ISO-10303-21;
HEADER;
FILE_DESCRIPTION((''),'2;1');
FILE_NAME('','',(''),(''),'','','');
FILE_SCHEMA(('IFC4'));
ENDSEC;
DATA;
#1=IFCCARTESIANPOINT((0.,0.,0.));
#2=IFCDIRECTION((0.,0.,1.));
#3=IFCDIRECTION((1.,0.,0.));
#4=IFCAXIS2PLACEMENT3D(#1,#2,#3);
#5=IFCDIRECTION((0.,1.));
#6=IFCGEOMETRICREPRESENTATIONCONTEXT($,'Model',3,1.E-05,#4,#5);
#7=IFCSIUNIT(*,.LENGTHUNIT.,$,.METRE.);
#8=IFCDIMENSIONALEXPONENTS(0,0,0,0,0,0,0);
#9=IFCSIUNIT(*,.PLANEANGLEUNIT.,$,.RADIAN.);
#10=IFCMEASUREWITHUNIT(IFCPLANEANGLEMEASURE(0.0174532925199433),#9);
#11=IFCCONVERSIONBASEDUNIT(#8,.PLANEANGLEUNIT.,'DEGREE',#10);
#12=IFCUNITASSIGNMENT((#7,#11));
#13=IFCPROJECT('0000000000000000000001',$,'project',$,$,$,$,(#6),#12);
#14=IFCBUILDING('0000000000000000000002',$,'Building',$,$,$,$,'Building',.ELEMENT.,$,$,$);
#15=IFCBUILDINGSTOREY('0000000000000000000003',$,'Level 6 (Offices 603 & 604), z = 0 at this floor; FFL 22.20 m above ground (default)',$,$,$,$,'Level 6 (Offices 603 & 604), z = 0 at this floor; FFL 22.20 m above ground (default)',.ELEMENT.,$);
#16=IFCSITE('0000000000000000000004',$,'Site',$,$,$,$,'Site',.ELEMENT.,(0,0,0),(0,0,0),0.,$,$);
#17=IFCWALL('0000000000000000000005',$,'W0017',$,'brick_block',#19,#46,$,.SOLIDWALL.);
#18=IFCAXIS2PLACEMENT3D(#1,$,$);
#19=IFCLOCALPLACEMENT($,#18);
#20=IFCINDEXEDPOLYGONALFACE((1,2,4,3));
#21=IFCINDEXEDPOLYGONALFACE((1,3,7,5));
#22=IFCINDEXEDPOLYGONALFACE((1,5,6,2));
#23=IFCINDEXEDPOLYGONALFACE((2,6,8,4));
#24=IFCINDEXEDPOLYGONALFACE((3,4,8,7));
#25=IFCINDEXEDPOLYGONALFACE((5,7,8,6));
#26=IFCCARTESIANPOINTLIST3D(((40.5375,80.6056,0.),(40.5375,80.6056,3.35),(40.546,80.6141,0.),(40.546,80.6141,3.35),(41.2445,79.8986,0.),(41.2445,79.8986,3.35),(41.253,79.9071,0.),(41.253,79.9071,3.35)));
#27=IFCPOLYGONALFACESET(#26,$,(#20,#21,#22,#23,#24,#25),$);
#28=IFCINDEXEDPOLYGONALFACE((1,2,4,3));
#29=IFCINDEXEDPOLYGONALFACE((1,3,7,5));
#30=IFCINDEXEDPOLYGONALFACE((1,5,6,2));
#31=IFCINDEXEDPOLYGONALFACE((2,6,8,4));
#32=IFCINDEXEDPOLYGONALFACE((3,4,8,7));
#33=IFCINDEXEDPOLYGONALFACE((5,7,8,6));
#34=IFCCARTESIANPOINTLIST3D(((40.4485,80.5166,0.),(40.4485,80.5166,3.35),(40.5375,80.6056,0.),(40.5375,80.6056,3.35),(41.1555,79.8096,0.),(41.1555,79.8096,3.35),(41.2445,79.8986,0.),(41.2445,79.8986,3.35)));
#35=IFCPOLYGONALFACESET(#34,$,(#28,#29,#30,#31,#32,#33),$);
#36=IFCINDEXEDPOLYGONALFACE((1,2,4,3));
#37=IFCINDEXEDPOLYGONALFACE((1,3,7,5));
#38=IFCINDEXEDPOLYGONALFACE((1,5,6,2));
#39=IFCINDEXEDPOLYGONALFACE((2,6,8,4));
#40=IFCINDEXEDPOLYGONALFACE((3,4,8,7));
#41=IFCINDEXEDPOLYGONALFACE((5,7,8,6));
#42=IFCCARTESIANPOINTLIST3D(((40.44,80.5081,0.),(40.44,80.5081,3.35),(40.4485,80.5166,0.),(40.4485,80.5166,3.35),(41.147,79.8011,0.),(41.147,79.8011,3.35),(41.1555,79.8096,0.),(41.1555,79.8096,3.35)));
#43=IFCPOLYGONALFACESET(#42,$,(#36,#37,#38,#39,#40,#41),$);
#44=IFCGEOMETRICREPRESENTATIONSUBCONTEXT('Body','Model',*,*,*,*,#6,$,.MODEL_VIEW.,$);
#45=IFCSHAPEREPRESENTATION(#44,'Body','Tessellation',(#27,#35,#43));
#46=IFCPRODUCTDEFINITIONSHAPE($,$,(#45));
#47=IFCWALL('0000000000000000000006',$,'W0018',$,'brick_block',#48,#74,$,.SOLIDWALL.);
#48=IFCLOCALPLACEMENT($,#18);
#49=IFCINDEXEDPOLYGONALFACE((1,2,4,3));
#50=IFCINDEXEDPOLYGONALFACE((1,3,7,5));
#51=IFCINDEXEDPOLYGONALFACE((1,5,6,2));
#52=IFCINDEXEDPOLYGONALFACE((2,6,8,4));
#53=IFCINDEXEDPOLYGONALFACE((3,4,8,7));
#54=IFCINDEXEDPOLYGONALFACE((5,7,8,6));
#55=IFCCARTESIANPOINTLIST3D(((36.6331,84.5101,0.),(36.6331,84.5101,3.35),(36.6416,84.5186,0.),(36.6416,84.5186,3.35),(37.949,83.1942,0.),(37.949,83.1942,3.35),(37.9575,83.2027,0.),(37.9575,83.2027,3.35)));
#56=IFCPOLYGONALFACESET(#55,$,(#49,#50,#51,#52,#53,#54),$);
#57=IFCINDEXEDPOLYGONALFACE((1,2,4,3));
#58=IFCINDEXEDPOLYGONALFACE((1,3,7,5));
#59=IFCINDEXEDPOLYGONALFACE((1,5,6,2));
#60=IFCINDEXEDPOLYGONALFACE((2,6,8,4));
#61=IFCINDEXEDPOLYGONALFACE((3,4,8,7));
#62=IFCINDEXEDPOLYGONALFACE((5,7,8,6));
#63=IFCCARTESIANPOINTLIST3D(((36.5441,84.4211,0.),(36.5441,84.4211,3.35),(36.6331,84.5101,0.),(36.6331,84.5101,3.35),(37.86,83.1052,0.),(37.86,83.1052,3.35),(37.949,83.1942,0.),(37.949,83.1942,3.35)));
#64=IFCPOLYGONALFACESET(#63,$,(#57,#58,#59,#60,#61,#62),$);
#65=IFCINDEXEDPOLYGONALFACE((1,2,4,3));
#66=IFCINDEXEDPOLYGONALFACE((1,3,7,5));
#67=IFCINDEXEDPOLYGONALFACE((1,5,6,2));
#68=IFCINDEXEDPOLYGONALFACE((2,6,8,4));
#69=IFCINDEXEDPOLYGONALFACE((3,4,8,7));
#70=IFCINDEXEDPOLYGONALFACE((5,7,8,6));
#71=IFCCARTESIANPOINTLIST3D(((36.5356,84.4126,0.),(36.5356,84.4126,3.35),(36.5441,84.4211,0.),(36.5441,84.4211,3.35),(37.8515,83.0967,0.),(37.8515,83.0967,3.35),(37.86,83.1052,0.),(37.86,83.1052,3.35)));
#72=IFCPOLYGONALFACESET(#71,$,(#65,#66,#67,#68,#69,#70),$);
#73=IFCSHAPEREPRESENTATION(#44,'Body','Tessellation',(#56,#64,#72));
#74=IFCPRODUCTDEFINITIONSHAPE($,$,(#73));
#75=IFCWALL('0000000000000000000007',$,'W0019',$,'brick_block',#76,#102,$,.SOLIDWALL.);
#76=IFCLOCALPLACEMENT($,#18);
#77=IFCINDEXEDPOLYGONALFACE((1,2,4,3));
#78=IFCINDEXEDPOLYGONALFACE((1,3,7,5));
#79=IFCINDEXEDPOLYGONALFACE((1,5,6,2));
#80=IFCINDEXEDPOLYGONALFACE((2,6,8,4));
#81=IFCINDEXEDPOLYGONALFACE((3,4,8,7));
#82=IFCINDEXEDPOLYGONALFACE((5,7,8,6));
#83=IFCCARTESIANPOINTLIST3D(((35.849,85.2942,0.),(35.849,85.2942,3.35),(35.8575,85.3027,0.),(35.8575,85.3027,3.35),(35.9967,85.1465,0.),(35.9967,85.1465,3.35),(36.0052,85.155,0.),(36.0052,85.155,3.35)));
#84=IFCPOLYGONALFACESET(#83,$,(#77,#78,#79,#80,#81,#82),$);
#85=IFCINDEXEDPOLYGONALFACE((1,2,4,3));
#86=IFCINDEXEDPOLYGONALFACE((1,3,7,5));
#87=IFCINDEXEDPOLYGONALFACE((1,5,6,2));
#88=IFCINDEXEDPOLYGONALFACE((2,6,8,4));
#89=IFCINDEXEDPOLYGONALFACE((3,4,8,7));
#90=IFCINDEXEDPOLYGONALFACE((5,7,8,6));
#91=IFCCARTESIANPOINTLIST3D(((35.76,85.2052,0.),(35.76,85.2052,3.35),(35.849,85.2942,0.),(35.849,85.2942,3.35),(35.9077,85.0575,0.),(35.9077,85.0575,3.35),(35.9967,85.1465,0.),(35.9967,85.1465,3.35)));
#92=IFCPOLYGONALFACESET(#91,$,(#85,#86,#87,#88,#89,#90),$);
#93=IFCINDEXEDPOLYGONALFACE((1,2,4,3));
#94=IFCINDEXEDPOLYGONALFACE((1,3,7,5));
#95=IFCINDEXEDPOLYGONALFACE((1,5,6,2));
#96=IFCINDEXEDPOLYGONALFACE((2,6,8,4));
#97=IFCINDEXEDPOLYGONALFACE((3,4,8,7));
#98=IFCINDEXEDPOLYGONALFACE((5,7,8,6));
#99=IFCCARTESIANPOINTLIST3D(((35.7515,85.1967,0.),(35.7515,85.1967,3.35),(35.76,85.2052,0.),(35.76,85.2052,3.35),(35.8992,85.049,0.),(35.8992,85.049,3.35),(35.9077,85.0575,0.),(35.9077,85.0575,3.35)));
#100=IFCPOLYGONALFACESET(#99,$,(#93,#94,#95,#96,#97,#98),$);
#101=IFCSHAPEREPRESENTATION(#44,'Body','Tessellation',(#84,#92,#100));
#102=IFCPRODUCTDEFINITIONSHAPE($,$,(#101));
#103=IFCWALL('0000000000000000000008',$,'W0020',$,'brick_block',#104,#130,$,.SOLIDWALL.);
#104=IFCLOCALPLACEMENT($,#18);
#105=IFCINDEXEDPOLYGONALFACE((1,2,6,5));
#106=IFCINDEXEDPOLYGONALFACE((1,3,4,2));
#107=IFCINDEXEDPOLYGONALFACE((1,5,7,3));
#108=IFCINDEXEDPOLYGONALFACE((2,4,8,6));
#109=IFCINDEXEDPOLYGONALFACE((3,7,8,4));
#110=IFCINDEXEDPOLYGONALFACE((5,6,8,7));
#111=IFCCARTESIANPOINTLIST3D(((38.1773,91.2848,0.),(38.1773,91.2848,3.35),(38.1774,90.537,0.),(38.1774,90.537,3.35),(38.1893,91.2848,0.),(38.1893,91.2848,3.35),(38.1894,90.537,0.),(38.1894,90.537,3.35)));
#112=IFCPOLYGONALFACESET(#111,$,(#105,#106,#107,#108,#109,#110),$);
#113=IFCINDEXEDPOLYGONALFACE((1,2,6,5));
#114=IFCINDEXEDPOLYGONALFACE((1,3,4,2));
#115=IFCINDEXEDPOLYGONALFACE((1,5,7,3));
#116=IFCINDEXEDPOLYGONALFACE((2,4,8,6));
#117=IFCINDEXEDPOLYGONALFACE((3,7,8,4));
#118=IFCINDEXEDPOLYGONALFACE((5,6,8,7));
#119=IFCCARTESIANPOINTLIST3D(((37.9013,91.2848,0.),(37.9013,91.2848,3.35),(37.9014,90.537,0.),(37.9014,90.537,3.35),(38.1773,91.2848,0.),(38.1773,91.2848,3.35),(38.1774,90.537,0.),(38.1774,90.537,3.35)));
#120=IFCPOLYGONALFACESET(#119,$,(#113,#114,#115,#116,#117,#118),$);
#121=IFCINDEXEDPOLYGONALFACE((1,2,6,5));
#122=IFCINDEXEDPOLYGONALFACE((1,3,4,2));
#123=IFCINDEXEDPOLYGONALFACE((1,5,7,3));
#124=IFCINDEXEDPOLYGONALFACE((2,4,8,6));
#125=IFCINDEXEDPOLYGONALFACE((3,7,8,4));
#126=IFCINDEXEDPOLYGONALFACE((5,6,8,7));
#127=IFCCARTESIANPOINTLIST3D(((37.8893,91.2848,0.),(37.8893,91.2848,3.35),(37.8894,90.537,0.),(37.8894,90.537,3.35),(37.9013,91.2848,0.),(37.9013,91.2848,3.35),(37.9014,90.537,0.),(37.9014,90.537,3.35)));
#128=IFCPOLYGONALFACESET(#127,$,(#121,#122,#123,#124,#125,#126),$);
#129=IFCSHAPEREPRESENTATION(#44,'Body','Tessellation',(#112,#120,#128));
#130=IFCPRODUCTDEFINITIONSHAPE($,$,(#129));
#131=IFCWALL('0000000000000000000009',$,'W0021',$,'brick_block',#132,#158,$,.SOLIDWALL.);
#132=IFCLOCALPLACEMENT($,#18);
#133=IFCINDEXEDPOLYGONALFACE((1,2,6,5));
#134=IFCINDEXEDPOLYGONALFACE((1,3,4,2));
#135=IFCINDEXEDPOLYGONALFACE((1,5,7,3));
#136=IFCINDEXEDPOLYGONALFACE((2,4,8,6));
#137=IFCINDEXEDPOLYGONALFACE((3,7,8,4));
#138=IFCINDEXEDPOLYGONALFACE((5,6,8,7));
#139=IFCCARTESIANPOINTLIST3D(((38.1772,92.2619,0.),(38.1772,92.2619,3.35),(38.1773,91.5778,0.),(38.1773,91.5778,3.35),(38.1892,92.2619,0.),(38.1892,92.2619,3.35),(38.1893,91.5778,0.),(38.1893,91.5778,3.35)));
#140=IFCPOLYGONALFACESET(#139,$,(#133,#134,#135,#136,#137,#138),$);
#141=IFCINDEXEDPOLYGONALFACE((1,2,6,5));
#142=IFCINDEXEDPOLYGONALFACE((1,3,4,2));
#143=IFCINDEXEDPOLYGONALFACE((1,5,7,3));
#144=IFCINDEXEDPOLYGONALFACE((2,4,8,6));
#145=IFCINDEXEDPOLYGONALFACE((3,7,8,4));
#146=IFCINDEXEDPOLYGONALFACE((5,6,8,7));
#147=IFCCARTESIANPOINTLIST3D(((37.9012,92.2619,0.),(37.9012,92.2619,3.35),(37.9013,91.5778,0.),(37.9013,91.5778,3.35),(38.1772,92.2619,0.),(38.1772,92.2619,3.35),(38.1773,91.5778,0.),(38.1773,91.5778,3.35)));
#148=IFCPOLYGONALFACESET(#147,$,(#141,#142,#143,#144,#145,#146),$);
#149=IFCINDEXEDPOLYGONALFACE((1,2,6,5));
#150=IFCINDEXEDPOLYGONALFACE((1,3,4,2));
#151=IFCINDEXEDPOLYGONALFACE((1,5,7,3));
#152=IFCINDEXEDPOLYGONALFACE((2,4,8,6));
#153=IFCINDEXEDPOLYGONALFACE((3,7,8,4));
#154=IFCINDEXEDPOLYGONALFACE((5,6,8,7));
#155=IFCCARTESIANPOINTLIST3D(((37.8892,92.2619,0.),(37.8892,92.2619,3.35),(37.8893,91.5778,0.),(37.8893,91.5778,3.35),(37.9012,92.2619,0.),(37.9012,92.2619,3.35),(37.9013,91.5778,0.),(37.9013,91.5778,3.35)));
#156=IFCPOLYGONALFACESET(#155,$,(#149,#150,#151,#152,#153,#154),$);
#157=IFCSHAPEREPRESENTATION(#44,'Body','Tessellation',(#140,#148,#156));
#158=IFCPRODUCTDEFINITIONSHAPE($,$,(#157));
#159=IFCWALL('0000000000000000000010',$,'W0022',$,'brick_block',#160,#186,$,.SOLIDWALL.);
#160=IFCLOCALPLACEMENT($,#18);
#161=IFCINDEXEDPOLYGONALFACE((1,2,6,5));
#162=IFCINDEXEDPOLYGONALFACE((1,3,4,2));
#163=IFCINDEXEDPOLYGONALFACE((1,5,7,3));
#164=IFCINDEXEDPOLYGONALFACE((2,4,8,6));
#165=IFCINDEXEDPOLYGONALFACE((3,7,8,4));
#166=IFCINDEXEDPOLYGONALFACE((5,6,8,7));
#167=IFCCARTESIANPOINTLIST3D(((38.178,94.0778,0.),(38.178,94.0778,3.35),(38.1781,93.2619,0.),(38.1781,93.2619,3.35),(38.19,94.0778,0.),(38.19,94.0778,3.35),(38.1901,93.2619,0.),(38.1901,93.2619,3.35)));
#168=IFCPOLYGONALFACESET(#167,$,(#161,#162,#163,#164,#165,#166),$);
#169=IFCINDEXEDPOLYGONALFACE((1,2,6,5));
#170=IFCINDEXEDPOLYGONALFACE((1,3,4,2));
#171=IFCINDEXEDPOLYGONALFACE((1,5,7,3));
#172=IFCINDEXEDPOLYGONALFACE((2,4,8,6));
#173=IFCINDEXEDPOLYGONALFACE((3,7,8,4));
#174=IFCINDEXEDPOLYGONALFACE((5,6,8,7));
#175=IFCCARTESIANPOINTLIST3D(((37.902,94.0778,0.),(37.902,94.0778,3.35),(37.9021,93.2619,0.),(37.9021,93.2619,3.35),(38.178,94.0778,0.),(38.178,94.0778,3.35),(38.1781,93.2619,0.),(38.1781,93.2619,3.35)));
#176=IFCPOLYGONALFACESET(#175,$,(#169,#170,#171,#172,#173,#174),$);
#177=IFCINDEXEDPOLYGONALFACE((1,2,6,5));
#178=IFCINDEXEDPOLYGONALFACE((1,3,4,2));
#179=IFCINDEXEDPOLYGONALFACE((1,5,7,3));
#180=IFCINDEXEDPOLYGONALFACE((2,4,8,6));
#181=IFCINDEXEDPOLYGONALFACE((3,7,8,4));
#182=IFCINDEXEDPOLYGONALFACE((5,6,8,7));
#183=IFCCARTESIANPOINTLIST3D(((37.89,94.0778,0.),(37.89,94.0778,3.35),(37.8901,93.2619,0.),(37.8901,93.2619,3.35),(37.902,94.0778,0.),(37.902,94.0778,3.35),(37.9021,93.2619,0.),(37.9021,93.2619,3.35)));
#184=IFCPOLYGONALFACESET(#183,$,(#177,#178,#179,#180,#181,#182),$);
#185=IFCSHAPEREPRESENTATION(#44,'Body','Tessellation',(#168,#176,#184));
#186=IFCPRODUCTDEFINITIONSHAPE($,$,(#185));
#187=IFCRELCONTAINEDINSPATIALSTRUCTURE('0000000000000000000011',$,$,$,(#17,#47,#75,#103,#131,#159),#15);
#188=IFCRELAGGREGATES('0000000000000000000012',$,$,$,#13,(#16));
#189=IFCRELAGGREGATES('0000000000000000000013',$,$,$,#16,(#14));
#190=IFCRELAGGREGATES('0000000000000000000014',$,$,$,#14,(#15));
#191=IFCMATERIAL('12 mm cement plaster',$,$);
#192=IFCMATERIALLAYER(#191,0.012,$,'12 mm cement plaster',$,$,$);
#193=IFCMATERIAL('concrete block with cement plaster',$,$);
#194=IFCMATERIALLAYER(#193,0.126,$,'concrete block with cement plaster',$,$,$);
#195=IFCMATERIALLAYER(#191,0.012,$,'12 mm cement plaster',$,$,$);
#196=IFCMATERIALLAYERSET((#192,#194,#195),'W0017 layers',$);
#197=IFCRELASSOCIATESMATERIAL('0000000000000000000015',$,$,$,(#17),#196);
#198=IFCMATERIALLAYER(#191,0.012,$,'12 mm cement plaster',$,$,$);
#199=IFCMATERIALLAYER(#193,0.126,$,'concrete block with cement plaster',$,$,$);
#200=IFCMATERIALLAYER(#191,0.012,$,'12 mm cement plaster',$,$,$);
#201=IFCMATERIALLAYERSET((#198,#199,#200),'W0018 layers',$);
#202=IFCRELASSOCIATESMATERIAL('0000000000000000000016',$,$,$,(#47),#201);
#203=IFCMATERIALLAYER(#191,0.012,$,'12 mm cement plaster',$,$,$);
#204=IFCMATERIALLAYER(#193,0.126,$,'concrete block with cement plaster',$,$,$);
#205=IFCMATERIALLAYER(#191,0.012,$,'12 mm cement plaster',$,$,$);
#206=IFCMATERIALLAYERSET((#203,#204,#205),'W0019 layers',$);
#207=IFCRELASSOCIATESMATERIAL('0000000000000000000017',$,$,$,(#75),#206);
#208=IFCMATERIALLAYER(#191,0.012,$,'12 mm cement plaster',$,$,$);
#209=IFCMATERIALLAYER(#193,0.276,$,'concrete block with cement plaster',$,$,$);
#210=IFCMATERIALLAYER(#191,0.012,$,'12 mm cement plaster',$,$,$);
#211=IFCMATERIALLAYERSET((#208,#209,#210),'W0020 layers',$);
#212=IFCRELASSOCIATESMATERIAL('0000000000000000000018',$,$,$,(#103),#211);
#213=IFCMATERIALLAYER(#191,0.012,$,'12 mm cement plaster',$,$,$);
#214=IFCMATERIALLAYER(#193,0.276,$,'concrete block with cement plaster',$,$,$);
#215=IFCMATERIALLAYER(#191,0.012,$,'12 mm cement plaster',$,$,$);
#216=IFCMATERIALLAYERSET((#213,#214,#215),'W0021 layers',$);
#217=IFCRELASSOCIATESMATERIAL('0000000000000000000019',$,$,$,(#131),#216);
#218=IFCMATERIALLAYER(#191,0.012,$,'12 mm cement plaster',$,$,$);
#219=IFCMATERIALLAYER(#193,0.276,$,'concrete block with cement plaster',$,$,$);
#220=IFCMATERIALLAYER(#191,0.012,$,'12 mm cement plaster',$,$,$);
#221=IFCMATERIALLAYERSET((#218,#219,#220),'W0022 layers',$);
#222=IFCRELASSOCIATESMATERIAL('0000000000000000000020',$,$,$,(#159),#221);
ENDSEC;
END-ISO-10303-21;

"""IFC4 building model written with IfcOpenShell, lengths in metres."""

from ifc_helpers import new_model, entity, si_unit, converted_unit, direction, frame, frame_2d, origin_with_axes, place, context, subcontext, project, spatial, rectangle, extrude, material, layer, layer_set, layer_usage, element, save


model = new_model("IFC4")

# Units and contexts
model_context = context("Model", 3, precision=1e-05, world=origin_with_axes(), true_north=direction((0.0, 1.0)))
body_context = subcontext(model_context, "Body", "Model", "MODEL_VIEW")
ifc_project = project(units=[si_unit("LENGTHUNIT", "METRE"), converted_unit("PLANEANGLEUNIT", "DEGREE", entity("IfcPlaneAngleMeasure", 0.0174532925199433), si_unit("PLANEANGLEUNIT", "RADIAN"), dimensions=[0, 0, 0, 0, 0, 0, 0])], contexts=[model_context])

# Site, building, storey
site = spatial("IfcSite", under=ifc_project, Name="Site", LongName="Site", CompositionType="ELEMENT", RefLatitude=(0, 0, 0), RefLongitude=(0, 0, 0), RefElevation=0.0)
building = spatial("IfcBuilding", under=site, Name="Building", LongName="Building", CompositionType="ELEMENT")
storey = spatial("IfcBuildingStorey", under=building, Name="Level 6 (Offices 603 & 604), z = 0 at this floor; FFL 22.20 m above ground (default)", LongName="Level 6 (Offices 603 & 604), z = 0 at this floor; FFL 22.20 m above ground (default)", CompositionType="ELEMENT")

# Shared definitions
ifc_material_1 = material(Name="12 mm cement plaster")
ifc_material_2 = material(Name="concrete block with cement plaster")
placement = place(None, origin_with_axes())

# Walls
ifc_layer_1 = layer(ifc_material_1, 0.012, Name="12 mm cement plaster")
ifc_layer_2 = layer(ifc_material_2, 0.126, Name="concrete block with cement plaster")
ifc_layer_3 = layer(ifc_material_1, 0.012, Name="12 mm cement plaster")
ifc_layer_set_1 = layer_set([ifc_layer_1, ifc_layer_2, ifc_layer_3], Name="W0017 layers")
ifc_layer_usage_1 = layer_usage(ifc_layer_set_1, "AXIS2", "POSITIVE", -0.075)
element("IfcWall", 1, at=placement, inside=storey, material=ifc_layer_usage_1, Name="W0017", ObjectType="brick_block", PredefinedType="SOLIDWALL", context=body_context, shape_type="SweptSolid", body=[
    extrude(rectangle(XDim=0.9998, YDim=0.012, at=frame_2d((0.0, 0.0), x_axis=(0.707107, -0.707107))), frame((40.8953, 80.2564, 0.0), z_axis=(0.0, 0.0, 1.0), x_axis=(1.0, 0.0, 0.0)), (0.0, 0.0, 1.0), 3.35),
    extrude(rectangle(XDim=0.9998, YDim=0.126, at=frame_2d((-0.0488, -0.0488), x_axis=(0.707107, -0.707107))), frame((40.8953, 80.2564, 0.0), z_axis=(0.0, 0.0, 1.0), x_axis=(1.0, 0.0, 0.0)), (0.0, 0.0, 1.0), 3.35),
    extrude(rectangle(XDim=0.9998, YDim=0.012, at=frame_2d((-0.0976, -0.0976), x_axis=(0.707107, -0.707107))), frame((40.8953, 80.2564, 0.0), z_axis=(0.0, 0.0, 1.0), x_axis=(1.0, 0.0, 0.0)), (0.0, 0.0, 1.0), 3.35),
])
ifc_layer_4 = layer(ifc_material_1, 0.012, Name="12 mm cement plaster")
ifc_layer_5 = layer(ifc_material_2, 0.126, Name="concrete block with cement plaster")
ifc_layer_6 = layer(ifc_material_1, 0.012, Name="12 mm cement plaster")
ifc_layer_set_2 = layer_set([ifc_layer_4, ifc_layer_5, ifc_layer_6], Name="W0018 layers")
ifc_layer_usage_2 = layer_usage(ifc_layer_set_2, "AXIS2", "POSITIVE", -0.075)
element("IfcWall", 2, at=placement, inside=storey, material=ifc_layer_usage_2, Name="W0018", ObjectType="brick_block", PredefinedType="SOLIDWALL", context=body_context, shape_type="SweptSolid", body=[
    extrude(rectangle(XDim=1.861, YDim=0.012, at=frame_2d((0.0, 0.0), x_axis=(0.707107, -0.707107))), frame((37.2953, 83.8564, 0.0), z_axis=(0.0, 0.0, 1.0), x_axis=(1.0, 0.0, 0.0)), (0.0, 0.0, 1.0), 3.35),
    extrude(rectangle(XDim=1.861, YDim=0.126, at=frame_2d((-0.0488, -0.0488), x_axis=(0.707107, -0.707107))), frame((37.2953, 83.8564, 0.0), z_axis=(0.0, 0.0, 1.0), x_axis=(1.0, 0.0, 0.0)), (0.0, 0.0, 1.0), 3.35),
    extrude(rectangle(XDim=1.861, YDim=0.012, at=frame_2d((-0.0976, -0.0976), x_axis=(0.707107, -0.707107))), frame((37.2953, 83.8564, 0.0), z_axis=(0.0, 0.0, 1.0), x_axis=(1.0, 0.0, 0.0)), (0.0, 0.0, 1.0), 3.35),
])
ifc_layer_7 = layer(ifc_material_1, 0.012, Name="12 mm cement plaster")
ifc_layer_8 = layer(ifc_material_2, 0.126, Name="concrete block with cement plaster")
ifc_layer_9 = layer(ifc_material_1, 0.012, Name="12 mm cement plaster")
ifc_layer_set_3 = layer_set([ifc_layer_7, ifc_layer_8, ifc_layer_9], Name="W0019 layers")
ifc_layer_usage_3 = layer_usage(ifc_layer_set_3, "AXIS2", "POSITIVE", -0.075)
element("IfcWall", 3, at=placement, inside=storey, material=ifc_layer_usage_3, Name="W0019", ObjectType="brick_block", PredefinedType="SOLIDWALL", context=body_context, shape_type="SweptSolid", body=[
    extrude(rectangle(XDim=0.2089, YDim=0.012, at=frame_2d((0.0, 0.0), x_axis=(0.707107, -0.707107))), frame((35.9271, 85.2246, 0.0), z_axis=(0.0, 0.0, 1.0), x_axis=(1.0, 0.0, 0.0)), (0.0, 0.0, 1.0), 3.35),
    extrude(rectangle(XDim=0.2089, YDim=0.126, at=frame_2d((-0.0488, -0.0488), x_axis=(0.707107, -0.707107))), frame((35.9271, 85.2246, 0.0), z_axis=(0.0, 0.0, 1.0), x_axis=(1.0, 0.0, 0.0)), (0.0, 0.0, 1.0), 3.35),
    extrude(rectangle(XDim=0.2089, YDim=0.012, at=frame_2d((-0.0976, -0.0976), x_axis=(0.707107, -0.707107))), frame((35.9271, 85.2246, 0.0), z_axis=(0.0, 0.0, 1.0), x_axis=(1.0, 0.0, 0.0)), (0.0, 0.0, 1.0), 3.35),
])
ifc_layer_10 = layer(ifc_material_1, 0.012, Name="12 mm cement plaster")
ifc_layer_11 = layer(ifc_material_2, 0.276, Name="concrete block with cement plaster")
ifc_layer_12 = layer(ifc_material_1, 0.012, Name="12 mm cement plaster")
ifc_layer_set_4 = layer_set([ifc_layer_10, ifc_layer_11, ifc_layer_12], Name="W0020 layers")
ifc_layer_usage_4 = layer_usage(ifc_layer_set_4, "AXIS2", "POSITIVE", -0.15)
element("IfcWall", 4, at=placement, inside=storey, material=ifc_layer_usage_4, Name="W0020", ObjectType="brick_block", PredefinedType="SOLIDWALL", context=body_context, shape_type="SweptSolid", body=[
    extrude(rectangle(XDim=0.7478, YDim=0.012, at=frame_2d((0.0, 0.0), x_axis=(-0.000134, 1.0))), frame((38.1833, 90.9109, 0.0), z_axis=(0.0, 0.0, 1.0), x_axis=(1.0, 0.0, 0.0)), (0.0, 0.0, 1.0), 3.35),
    extrude(rectangle(XDim=0.7478, YDim=0.276, at=frame_2d((-0.144, 0.0), x_axis=(-0.000134, 1.0))), frame((38.1833, 90.9109, 0.0), z_axis=(0.0, 0.0, 1.0), x_axis=(1.0, 0.0, 0.0)), (0.0, 0.0, 1.0), 3.35),
    extrude(rectangle(XDim=0.7478, YDim=0.012, at=frame_2d((-0.288, 0.0), x_axis=(-0.000134, 1.0))), frame((38.1833, 90.9109, 0.0), z_axis=(0.0, 0.0, 1.0), x_axis=(1.0, 0.0, 0.0)), (0.0, 0.0, 1.0), 3.35),
])
ifc_layer_13 = layer(ifc_material_1, 0.012, Name="12 mm cement plaster")
ifc_layer_14 = layer(ifc_material_2, 0.276, Name="concrete block with cement plaster")
ifc_layer_15 = layer(ifc_material_1, 0.012, Name="12 mm cement plaster")
ifc_layer_set_5 = layer_set([ifc_layer_13, ifc_layer_14, ifc_layer_15], Name="W0021 layers")
ifc_layer_usage_5 = layer_usage(ifc_layer_set_5, "AXIS2", "POSITIVE", -0.15)
element("IfcWall", 5, at=placement, inside=storey, material=ifc_layer_usage_5, Name="W0021", ObjectType="brick_block", PredefinedType="SOLIDWALL", context=body_context, shape_type="SweptSolid", body=[
    extrude(rectangle(XDim=0.6841, YDim=0.012, at=frame_2d((0.0, 0.0), x_axis=(-0.000146, 1.0))), frame((38.1832, 91.9199, 0.0), z_axis=(0.0, 0.0, 1.0), x_axis=(1.0, 0.0, 0.0)), (0.0, 0.0, 1.0), 3.35),
    extrude(rectangle(XDim=0.6841, YDim=0.276, at=frame_2d((-0.144, 0.0), x_axis=(-0.000146, 1.0))), frame((38.1832, 91.9199, 0.0), z_axis=(0.0, 0.0, 1.0), x_axis=(1.0, 0.0, 0.0)), (0.0, 0.0, 1.0), 3.35),
    extrude(rectangle(XDim=0.6841, YDim=0.012, at=frame_2d((-0.288, 0.0), x_axis=(-0.000146, 1.0))), frame((38.1832, 91.9199, 0.0), z_axis=(0.0, 0.0, 1.0), x_axis=(1.0, 0.0, 0.0)), (0.0, 0.0, 1.0), 3.35),
])
ifc_layer_16 = layer(ifc_material_1, 0.012, Name="12 mm cement plaster")
ifc_layer_17 = layer(ifc_material_2, 0.276, Name="concrete block with cement plaster")
ifc_layer_18 = layer(ifc_material_1, 0.012, Name="12 mm cement plaster")
ifc_layer_set_6 = layer_set([ifc_layer_16, ifc_layer_17, ifc_layer_18], Name="W0022 layers")
ifc_layer_usage_6 = layer_usage(ifc_layer_set_6, "AXIS2", "POSITIVE", -0.15)
element("IfcWall", 6, at=placement, inside=storey, material=ifc_layer_usage_6, Name="W0022", ObjectType="brick_block", PredefinedType="SOLIDWALL", context=body_context, shape_type="SweptSolid", body=[
    extrude(rectangle(XDim=0.8159, YDim=0.012, at=frame_2d((0.0, 0.0), x_axis=(-0.000123, 1.0))), frame((38.184, 93.6699, 0.0), z_axis=(0.0, 0.0, 1.0), x_axis=(1.0, 0.0, 0.0)), (0.0, 0.0, 1.0), 3.35),
    extrude(rectangle(XDim=0.8159, YDim=0.276, at=frame_2d((-0.144, 0.0), x_axis=(-0.000123, 1.0))), frame((38.184, 93.6699, 0.0), z_axis=(0.0, 0.0, 1.0), x_axis=(1.0, 0.0, 0.0)), (0.0, 0.0, 1.0), 3.35),
    extrude(rectangle(XDim=0.8159, YDim=0.012, at=frame_2d((-0.288, 0.0), x_axis=(-0.000123, 1.0))), frame((38.184, 93.6699, 0.0), z_axis=(0.0, 0.0, 1.0), x_axis=(1.0, 0.0, 0.0)), (0.0, 0.0, 1.0), 3.35),
])

save(model, "model.ifc")
